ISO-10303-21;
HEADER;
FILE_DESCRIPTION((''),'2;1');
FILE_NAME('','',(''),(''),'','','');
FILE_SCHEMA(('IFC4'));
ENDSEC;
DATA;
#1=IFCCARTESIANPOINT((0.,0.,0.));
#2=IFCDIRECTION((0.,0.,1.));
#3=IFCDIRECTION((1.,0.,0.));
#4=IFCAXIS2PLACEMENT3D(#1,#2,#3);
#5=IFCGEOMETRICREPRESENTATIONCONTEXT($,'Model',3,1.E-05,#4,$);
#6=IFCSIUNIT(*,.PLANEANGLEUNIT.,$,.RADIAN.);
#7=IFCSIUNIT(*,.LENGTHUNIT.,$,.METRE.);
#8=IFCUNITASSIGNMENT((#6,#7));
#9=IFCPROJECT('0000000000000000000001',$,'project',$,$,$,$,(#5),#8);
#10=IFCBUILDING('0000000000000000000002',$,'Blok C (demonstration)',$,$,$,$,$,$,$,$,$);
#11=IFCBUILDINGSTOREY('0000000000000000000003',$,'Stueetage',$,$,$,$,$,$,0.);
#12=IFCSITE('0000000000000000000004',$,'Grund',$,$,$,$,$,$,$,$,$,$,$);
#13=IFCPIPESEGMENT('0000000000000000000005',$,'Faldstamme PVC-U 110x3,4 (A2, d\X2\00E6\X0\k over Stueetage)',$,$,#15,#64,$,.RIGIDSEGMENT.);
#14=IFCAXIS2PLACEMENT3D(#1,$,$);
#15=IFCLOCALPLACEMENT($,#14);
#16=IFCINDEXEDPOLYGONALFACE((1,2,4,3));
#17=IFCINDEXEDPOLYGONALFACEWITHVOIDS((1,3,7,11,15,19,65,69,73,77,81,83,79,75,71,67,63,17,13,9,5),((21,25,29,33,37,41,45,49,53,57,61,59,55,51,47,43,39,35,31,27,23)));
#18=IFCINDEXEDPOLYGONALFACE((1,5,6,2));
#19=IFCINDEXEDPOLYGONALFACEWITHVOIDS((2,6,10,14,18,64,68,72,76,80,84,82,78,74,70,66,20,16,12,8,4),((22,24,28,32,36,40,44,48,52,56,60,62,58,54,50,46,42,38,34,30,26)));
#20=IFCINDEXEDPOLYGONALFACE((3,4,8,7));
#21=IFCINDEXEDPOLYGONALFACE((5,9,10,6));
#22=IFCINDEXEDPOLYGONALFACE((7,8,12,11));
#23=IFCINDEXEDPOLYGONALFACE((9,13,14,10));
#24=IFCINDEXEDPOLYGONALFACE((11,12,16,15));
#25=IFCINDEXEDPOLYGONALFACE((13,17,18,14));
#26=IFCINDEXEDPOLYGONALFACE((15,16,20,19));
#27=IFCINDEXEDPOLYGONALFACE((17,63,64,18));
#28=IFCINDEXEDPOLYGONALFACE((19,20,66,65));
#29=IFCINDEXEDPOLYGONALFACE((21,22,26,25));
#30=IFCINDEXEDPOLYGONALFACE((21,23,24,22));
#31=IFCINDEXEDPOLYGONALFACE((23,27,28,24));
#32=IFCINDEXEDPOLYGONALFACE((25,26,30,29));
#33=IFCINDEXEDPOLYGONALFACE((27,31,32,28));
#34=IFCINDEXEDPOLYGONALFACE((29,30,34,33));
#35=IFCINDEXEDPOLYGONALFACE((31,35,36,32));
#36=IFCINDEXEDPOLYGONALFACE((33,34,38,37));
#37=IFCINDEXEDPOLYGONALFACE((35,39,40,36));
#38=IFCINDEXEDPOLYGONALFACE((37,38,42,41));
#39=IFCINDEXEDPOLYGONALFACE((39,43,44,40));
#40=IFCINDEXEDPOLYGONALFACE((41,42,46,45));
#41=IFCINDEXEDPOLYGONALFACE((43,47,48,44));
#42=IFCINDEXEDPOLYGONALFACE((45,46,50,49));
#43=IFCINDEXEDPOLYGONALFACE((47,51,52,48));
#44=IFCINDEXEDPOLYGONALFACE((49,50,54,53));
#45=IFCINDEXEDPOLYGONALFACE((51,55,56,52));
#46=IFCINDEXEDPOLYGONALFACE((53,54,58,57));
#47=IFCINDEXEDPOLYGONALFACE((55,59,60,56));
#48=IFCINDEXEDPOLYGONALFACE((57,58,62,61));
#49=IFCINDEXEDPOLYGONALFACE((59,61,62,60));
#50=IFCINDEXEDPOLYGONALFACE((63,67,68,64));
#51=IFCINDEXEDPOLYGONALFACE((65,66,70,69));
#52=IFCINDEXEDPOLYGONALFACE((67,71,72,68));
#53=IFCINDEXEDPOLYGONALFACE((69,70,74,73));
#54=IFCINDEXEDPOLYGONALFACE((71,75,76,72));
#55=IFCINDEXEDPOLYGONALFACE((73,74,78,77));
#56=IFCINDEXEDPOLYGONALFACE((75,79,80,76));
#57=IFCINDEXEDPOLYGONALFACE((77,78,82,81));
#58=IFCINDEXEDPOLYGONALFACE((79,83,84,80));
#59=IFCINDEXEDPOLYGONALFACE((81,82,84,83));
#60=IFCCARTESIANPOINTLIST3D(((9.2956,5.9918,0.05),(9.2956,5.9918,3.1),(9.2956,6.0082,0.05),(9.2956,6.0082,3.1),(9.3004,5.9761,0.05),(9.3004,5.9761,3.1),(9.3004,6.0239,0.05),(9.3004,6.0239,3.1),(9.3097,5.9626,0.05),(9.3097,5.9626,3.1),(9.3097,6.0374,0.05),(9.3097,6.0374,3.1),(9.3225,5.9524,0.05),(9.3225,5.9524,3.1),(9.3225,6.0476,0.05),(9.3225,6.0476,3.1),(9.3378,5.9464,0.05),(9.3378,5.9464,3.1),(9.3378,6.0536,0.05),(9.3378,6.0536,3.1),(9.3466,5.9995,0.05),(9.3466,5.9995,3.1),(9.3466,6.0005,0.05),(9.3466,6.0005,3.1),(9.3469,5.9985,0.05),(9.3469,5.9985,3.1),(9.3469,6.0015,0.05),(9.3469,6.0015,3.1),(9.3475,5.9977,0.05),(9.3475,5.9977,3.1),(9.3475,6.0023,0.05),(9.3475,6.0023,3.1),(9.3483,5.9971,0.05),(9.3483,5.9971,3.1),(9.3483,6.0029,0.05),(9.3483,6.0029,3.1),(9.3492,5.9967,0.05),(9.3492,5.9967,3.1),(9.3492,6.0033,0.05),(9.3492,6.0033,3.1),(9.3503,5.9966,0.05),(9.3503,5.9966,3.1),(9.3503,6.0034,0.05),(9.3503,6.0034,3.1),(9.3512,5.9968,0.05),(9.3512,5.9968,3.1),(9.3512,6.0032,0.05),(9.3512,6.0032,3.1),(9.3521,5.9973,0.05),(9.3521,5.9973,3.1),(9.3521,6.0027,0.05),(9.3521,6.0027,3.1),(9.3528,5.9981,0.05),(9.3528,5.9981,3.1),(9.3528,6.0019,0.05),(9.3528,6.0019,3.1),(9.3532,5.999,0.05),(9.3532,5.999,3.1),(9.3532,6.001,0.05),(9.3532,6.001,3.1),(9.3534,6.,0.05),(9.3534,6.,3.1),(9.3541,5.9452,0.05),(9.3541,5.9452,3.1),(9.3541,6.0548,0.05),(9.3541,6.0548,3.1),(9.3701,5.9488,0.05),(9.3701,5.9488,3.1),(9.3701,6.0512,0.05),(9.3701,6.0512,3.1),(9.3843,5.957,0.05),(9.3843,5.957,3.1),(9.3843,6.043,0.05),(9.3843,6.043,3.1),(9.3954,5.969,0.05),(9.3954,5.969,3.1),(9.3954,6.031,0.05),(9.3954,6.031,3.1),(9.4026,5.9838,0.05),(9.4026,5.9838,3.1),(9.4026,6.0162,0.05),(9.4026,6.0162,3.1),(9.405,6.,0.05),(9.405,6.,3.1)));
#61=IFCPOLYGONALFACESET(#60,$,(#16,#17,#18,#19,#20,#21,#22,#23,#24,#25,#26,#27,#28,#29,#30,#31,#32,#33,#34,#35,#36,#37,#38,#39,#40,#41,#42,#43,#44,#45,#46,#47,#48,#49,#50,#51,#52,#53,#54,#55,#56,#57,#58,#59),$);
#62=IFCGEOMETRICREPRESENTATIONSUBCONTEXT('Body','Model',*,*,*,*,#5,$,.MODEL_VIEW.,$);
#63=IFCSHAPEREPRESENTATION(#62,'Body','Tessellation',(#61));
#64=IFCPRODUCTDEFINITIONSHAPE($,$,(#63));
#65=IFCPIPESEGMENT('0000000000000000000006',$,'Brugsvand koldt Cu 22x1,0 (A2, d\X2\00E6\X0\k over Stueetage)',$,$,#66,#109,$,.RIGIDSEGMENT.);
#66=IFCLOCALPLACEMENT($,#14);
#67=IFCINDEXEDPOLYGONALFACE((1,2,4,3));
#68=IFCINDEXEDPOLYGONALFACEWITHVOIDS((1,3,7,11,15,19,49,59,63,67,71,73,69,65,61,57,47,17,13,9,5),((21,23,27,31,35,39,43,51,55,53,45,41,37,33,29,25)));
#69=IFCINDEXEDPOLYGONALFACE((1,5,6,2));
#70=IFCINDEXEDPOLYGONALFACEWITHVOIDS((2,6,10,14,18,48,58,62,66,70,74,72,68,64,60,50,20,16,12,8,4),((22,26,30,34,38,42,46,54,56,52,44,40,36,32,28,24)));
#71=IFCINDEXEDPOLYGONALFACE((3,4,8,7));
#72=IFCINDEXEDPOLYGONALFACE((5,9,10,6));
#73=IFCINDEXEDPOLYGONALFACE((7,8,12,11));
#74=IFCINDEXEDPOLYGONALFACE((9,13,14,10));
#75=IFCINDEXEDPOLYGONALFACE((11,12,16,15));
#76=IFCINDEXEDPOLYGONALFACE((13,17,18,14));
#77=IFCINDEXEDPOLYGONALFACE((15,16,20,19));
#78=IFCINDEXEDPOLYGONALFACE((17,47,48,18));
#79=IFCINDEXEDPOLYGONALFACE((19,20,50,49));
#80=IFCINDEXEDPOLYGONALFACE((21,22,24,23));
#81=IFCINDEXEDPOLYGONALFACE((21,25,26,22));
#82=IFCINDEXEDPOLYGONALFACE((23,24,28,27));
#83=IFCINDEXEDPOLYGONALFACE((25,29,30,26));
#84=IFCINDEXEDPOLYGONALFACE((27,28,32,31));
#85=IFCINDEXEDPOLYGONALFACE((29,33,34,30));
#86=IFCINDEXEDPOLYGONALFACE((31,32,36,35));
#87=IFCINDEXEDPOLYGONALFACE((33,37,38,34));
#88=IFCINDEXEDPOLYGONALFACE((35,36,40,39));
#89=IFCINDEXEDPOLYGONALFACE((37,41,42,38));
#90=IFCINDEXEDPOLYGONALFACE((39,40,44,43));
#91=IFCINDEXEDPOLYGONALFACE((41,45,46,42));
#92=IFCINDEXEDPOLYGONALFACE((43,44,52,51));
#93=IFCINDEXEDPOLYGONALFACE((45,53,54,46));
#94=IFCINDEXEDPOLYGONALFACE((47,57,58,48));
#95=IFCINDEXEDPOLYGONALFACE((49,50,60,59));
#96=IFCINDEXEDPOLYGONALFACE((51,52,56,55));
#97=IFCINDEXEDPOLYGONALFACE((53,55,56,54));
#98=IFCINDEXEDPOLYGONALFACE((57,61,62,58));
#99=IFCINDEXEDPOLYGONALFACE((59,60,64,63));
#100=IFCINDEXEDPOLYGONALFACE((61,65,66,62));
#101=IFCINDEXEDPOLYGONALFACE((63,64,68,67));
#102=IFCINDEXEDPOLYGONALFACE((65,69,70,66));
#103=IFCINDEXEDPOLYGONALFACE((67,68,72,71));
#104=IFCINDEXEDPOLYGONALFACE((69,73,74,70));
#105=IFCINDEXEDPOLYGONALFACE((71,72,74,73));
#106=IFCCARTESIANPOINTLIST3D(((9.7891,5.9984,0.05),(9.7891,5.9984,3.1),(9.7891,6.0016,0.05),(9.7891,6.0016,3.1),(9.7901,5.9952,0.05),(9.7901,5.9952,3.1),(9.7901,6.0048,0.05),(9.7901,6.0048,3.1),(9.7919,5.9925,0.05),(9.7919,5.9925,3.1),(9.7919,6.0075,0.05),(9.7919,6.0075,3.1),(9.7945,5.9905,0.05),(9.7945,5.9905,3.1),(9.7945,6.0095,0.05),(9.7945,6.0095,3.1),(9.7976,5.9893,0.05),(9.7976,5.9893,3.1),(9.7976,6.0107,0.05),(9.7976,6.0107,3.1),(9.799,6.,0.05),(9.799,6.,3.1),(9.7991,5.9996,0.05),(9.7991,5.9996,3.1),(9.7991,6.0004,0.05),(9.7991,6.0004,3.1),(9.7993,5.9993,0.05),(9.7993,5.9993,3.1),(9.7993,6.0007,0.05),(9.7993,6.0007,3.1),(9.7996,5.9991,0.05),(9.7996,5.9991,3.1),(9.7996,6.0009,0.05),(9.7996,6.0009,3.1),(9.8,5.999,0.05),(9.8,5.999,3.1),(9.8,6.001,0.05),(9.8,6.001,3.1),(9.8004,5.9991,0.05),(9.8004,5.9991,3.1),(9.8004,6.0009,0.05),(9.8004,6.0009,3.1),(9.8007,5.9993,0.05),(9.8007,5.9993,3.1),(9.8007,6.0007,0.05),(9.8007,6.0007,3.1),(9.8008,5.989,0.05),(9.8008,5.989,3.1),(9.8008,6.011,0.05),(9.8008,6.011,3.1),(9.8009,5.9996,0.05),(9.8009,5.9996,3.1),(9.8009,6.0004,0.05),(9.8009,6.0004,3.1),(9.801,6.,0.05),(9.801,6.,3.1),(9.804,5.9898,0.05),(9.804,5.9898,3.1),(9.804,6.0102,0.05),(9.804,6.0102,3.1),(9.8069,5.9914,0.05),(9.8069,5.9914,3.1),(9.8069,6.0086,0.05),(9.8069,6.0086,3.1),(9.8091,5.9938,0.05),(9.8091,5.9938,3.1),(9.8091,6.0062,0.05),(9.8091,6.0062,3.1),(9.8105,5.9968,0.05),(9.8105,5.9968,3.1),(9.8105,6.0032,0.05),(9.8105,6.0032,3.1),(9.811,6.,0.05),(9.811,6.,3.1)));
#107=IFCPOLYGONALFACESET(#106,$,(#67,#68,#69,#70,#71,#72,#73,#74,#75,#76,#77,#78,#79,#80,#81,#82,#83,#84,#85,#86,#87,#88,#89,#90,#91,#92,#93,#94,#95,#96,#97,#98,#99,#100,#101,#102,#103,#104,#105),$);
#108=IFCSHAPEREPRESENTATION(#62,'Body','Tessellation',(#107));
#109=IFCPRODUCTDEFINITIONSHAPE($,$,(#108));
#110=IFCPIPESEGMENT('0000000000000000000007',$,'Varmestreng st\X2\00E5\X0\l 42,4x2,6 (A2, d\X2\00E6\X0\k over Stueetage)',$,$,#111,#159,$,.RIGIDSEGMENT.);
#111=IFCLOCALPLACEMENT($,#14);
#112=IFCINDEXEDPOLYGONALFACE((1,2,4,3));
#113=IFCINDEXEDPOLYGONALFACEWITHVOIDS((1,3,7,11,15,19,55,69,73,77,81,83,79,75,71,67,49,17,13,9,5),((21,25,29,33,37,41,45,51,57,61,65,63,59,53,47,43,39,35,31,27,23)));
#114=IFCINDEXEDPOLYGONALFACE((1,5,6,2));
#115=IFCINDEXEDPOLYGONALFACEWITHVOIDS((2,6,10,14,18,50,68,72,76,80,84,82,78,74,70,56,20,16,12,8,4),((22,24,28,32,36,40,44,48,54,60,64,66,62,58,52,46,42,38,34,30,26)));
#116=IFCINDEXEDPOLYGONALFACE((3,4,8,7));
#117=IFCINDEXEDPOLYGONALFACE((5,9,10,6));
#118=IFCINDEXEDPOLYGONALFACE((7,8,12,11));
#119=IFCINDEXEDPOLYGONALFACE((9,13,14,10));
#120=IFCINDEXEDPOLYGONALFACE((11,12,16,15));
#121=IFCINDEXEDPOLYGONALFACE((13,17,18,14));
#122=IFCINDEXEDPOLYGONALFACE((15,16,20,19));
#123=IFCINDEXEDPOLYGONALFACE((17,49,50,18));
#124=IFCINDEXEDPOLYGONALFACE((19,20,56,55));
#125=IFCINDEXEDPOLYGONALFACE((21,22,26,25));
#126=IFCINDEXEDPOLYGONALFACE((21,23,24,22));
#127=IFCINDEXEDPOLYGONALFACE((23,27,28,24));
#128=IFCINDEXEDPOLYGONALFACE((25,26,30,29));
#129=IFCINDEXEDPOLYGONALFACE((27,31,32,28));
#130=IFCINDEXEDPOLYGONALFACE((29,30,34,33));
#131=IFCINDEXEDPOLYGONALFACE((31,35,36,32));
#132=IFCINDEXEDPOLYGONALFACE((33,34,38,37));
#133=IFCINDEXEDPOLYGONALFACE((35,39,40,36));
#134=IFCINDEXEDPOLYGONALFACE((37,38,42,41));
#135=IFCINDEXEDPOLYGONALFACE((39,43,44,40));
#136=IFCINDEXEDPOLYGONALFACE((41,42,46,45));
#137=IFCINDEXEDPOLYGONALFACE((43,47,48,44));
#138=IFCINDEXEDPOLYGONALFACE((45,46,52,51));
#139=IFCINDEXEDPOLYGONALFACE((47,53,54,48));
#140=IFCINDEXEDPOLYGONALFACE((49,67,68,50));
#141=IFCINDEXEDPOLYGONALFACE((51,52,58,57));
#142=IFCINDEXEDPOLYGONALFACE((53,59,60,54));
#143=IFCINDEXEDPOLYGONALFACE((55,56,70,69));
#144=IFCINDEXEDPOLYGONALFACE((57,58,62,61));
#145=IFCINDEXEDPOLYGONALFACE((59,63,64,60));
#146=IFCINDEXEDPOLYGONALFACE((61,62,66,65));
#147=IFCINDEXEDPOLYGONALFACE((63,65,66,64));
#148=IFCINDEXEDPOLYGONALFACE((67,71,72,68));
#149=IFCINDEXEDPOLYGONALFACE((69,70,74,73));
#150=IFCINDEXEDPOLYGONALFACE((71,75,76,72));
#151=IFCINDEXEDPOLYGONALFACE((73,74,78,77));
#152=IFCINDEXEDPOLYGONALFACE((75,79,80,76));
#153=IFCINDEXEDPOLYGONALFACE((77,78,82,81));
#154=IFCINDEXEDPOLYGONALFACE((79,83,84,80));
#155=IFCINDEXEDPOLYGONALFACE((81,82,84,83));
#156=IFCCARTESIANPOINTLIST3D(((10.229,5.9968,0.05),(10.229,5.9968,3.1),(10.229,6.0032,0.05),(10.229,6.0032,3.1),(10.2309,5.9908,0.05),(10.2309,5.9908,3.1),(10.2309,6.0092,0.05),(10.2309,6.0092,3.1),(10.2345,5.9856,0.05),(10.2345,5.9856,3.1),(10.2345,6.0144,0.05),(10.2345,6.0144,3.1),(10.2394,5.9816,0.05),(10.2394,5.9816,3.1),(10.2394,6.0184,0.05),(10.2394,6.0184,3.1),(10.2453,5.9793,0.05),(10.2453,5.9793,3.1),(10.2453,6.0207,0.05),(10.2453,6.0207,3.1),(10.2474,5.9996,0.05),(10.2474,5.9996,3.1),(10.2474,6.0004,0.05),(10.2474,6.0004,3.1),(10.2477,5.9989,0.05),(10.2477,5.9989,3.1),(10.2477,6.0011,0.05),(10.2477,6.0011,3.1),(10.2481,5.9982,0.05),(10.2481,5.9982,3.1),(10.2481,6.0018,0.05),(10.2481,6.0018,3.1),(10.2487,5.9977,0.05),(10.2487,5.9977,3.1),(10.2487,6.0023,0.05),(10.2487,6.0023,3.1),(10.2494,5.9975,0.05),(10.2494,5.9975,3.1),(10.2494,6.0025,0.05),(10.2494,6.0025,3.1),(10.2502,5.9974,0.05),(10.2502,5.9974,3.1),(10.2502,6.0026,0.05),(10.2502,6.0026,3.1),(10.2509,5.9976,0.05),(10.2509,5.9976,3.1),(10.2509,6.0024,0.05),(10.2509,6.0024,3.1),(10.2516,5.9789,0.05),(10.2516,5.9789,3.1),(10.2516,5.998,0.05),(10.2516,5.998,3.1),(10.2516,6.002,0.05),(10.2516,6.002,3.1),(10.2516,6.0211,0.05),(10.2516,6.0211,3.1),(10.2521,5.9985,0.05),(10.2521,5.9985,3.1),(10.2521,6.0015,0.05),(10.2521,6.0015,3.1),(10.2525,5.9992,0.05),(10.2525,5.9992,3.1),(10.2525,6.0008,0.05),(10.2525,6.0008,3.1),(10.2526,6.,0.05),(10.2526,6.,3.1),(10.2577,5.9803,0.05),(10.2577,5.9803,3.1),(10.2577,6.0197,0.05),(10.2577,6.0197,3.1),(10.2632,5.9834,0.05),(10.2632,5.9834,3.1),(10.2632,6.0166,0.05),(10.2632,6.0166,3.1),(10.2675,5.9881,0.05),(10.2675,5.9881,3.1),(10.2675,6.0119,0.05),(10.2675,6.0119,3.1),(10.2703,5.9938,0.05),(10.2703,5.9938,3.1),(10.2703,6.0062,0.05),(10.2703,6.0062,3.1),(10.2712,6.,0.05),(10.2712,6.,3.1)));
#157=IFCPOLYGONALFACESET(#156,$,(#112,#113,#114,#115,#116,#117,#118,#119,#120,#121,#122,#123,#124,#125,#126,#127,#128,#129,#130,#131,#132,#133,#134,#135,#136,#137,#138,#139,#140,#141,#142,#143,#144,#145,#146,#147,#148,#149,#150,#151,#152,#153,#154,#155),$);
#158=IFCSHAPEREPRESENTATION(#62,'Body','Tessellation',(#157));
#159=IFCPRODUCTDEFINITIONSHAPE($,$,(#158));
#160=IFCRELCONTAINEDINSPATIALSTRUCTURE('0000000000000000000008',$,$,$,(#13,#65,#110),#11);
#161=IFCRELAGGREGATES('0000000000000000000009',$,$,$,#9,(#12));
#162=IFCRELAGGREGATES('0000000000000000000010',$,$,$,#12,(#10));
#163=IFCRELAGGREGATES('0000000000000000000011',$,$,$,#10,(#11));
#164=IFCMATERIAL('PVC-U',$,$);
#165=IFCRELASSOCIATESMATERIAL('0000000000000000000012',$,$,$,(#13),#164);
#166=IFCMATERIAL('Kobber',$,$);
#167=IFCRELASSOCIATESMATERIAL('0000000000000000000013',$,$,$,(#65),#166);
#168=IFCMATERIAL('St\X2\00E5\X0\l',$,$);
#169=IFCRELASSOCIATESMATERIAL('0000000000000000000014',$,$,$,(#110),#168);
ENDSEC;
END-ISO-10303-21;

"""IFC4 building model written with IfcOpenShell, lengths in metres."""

from ifc_helpers import new_model, si_unit, frame, origin_with_axes, place, context, subcontext, project, spatial, hollow_circle, extrude, material, element, save


model = new_model("IFC4")

# Units and contexts
model_context = context("Model", 3, precision=1e-05, world=origin_with_axes())
body_context = subcontext(model_context, "Body", "Model", "MODEL_VIEW")
ifc_project = project(units=[si_unit("PLANEANGLEUNIT", "RADIAN"), si_unit("LENGTHUNIT", "METRE")], contexts=[model_context])

# Site, building, storey
site = spatial("IfcSite", under=ifc_project, Name="Grund")
building = spatial("IfcBuilding", under=site, Name="Blok C (demonstration)")
storey = spatial("IfcBuildingStorey", under=building, Name="Stueetage", Elevation=0.0)

# Pipe segments
ifc_material_1 = material(Name="PVC-U")
ifc_material_2 = material(Name="Kobber")
ifc_material_3 = material(Name="Stål")
pipe_segment_1_placement = place(None, origin_with_axes())
element("IfcPipeSegment", 1, at=pipe_segment_1_placement, inside=storey, material=ifc_material_1, Name="Faldstamme PVC-U 110x3,4 (A2, dæk over Stueetage)", PredefinedType="RIGIDSEGMENT", context=body_context, shape_type="SweptSolid", body=[
    extrude(hollow_circle(Radius=0.055, WallThickness=0.0516), frame((9.35, 6.0, 0.05), z_axis=(0.0, 0.0, 1.0), x_axis=(1.0, 0.0, 0.0)), (0.0, 0.0, 1.0), 3.05),
])
pipe_segment_2_placement = place(None, origin_with_axes())
element("IfcPipeSegment", 2, at=pipe_segment_2_placement, inside=storey, material=ifc_material_2, Name="Brugsvand koldt Cu 22x1,0 (A2, dæk over Stueetage)", PredefinedType="RIGIDSEGMENT", context=body_context, shape_type="SweptSolid", body=[
    extrude(hollow_circle(Radius=0.011, WallThickness=0.01), frame((9.8, 6.0, 0.05), z_axis=(0.0, 0.0, 1.0), x_axis=(1.0, 0.0, 0.0)), (0.0, 0.0, 1.0), 3.05),
])
pipe_segment_3_placement = place(None, origin_with_axes())
element("IfcPipeSegment", 3, at=pipe_segment_3_placement, inside=storey, material=ifc_material_3, Name="Varmestreng stål 42,4x2,6 (A2, dæk over Stueetage)", PredefinedType="RIGIDSEGMENT", context=body_context, shape_type="SweptSolid", body=[
    extrude(hollow_circle(Radius=0.0212, WallThickness=0.0186), frame((10.25, 6.0, 0.05), z_axis=(0.0, 0.0, 1.0), x_axis=(1.0, 0.0, 0.0)), (0.0, 0.0, 1.0), 3.05),
])

save(model, "model.ifc")
